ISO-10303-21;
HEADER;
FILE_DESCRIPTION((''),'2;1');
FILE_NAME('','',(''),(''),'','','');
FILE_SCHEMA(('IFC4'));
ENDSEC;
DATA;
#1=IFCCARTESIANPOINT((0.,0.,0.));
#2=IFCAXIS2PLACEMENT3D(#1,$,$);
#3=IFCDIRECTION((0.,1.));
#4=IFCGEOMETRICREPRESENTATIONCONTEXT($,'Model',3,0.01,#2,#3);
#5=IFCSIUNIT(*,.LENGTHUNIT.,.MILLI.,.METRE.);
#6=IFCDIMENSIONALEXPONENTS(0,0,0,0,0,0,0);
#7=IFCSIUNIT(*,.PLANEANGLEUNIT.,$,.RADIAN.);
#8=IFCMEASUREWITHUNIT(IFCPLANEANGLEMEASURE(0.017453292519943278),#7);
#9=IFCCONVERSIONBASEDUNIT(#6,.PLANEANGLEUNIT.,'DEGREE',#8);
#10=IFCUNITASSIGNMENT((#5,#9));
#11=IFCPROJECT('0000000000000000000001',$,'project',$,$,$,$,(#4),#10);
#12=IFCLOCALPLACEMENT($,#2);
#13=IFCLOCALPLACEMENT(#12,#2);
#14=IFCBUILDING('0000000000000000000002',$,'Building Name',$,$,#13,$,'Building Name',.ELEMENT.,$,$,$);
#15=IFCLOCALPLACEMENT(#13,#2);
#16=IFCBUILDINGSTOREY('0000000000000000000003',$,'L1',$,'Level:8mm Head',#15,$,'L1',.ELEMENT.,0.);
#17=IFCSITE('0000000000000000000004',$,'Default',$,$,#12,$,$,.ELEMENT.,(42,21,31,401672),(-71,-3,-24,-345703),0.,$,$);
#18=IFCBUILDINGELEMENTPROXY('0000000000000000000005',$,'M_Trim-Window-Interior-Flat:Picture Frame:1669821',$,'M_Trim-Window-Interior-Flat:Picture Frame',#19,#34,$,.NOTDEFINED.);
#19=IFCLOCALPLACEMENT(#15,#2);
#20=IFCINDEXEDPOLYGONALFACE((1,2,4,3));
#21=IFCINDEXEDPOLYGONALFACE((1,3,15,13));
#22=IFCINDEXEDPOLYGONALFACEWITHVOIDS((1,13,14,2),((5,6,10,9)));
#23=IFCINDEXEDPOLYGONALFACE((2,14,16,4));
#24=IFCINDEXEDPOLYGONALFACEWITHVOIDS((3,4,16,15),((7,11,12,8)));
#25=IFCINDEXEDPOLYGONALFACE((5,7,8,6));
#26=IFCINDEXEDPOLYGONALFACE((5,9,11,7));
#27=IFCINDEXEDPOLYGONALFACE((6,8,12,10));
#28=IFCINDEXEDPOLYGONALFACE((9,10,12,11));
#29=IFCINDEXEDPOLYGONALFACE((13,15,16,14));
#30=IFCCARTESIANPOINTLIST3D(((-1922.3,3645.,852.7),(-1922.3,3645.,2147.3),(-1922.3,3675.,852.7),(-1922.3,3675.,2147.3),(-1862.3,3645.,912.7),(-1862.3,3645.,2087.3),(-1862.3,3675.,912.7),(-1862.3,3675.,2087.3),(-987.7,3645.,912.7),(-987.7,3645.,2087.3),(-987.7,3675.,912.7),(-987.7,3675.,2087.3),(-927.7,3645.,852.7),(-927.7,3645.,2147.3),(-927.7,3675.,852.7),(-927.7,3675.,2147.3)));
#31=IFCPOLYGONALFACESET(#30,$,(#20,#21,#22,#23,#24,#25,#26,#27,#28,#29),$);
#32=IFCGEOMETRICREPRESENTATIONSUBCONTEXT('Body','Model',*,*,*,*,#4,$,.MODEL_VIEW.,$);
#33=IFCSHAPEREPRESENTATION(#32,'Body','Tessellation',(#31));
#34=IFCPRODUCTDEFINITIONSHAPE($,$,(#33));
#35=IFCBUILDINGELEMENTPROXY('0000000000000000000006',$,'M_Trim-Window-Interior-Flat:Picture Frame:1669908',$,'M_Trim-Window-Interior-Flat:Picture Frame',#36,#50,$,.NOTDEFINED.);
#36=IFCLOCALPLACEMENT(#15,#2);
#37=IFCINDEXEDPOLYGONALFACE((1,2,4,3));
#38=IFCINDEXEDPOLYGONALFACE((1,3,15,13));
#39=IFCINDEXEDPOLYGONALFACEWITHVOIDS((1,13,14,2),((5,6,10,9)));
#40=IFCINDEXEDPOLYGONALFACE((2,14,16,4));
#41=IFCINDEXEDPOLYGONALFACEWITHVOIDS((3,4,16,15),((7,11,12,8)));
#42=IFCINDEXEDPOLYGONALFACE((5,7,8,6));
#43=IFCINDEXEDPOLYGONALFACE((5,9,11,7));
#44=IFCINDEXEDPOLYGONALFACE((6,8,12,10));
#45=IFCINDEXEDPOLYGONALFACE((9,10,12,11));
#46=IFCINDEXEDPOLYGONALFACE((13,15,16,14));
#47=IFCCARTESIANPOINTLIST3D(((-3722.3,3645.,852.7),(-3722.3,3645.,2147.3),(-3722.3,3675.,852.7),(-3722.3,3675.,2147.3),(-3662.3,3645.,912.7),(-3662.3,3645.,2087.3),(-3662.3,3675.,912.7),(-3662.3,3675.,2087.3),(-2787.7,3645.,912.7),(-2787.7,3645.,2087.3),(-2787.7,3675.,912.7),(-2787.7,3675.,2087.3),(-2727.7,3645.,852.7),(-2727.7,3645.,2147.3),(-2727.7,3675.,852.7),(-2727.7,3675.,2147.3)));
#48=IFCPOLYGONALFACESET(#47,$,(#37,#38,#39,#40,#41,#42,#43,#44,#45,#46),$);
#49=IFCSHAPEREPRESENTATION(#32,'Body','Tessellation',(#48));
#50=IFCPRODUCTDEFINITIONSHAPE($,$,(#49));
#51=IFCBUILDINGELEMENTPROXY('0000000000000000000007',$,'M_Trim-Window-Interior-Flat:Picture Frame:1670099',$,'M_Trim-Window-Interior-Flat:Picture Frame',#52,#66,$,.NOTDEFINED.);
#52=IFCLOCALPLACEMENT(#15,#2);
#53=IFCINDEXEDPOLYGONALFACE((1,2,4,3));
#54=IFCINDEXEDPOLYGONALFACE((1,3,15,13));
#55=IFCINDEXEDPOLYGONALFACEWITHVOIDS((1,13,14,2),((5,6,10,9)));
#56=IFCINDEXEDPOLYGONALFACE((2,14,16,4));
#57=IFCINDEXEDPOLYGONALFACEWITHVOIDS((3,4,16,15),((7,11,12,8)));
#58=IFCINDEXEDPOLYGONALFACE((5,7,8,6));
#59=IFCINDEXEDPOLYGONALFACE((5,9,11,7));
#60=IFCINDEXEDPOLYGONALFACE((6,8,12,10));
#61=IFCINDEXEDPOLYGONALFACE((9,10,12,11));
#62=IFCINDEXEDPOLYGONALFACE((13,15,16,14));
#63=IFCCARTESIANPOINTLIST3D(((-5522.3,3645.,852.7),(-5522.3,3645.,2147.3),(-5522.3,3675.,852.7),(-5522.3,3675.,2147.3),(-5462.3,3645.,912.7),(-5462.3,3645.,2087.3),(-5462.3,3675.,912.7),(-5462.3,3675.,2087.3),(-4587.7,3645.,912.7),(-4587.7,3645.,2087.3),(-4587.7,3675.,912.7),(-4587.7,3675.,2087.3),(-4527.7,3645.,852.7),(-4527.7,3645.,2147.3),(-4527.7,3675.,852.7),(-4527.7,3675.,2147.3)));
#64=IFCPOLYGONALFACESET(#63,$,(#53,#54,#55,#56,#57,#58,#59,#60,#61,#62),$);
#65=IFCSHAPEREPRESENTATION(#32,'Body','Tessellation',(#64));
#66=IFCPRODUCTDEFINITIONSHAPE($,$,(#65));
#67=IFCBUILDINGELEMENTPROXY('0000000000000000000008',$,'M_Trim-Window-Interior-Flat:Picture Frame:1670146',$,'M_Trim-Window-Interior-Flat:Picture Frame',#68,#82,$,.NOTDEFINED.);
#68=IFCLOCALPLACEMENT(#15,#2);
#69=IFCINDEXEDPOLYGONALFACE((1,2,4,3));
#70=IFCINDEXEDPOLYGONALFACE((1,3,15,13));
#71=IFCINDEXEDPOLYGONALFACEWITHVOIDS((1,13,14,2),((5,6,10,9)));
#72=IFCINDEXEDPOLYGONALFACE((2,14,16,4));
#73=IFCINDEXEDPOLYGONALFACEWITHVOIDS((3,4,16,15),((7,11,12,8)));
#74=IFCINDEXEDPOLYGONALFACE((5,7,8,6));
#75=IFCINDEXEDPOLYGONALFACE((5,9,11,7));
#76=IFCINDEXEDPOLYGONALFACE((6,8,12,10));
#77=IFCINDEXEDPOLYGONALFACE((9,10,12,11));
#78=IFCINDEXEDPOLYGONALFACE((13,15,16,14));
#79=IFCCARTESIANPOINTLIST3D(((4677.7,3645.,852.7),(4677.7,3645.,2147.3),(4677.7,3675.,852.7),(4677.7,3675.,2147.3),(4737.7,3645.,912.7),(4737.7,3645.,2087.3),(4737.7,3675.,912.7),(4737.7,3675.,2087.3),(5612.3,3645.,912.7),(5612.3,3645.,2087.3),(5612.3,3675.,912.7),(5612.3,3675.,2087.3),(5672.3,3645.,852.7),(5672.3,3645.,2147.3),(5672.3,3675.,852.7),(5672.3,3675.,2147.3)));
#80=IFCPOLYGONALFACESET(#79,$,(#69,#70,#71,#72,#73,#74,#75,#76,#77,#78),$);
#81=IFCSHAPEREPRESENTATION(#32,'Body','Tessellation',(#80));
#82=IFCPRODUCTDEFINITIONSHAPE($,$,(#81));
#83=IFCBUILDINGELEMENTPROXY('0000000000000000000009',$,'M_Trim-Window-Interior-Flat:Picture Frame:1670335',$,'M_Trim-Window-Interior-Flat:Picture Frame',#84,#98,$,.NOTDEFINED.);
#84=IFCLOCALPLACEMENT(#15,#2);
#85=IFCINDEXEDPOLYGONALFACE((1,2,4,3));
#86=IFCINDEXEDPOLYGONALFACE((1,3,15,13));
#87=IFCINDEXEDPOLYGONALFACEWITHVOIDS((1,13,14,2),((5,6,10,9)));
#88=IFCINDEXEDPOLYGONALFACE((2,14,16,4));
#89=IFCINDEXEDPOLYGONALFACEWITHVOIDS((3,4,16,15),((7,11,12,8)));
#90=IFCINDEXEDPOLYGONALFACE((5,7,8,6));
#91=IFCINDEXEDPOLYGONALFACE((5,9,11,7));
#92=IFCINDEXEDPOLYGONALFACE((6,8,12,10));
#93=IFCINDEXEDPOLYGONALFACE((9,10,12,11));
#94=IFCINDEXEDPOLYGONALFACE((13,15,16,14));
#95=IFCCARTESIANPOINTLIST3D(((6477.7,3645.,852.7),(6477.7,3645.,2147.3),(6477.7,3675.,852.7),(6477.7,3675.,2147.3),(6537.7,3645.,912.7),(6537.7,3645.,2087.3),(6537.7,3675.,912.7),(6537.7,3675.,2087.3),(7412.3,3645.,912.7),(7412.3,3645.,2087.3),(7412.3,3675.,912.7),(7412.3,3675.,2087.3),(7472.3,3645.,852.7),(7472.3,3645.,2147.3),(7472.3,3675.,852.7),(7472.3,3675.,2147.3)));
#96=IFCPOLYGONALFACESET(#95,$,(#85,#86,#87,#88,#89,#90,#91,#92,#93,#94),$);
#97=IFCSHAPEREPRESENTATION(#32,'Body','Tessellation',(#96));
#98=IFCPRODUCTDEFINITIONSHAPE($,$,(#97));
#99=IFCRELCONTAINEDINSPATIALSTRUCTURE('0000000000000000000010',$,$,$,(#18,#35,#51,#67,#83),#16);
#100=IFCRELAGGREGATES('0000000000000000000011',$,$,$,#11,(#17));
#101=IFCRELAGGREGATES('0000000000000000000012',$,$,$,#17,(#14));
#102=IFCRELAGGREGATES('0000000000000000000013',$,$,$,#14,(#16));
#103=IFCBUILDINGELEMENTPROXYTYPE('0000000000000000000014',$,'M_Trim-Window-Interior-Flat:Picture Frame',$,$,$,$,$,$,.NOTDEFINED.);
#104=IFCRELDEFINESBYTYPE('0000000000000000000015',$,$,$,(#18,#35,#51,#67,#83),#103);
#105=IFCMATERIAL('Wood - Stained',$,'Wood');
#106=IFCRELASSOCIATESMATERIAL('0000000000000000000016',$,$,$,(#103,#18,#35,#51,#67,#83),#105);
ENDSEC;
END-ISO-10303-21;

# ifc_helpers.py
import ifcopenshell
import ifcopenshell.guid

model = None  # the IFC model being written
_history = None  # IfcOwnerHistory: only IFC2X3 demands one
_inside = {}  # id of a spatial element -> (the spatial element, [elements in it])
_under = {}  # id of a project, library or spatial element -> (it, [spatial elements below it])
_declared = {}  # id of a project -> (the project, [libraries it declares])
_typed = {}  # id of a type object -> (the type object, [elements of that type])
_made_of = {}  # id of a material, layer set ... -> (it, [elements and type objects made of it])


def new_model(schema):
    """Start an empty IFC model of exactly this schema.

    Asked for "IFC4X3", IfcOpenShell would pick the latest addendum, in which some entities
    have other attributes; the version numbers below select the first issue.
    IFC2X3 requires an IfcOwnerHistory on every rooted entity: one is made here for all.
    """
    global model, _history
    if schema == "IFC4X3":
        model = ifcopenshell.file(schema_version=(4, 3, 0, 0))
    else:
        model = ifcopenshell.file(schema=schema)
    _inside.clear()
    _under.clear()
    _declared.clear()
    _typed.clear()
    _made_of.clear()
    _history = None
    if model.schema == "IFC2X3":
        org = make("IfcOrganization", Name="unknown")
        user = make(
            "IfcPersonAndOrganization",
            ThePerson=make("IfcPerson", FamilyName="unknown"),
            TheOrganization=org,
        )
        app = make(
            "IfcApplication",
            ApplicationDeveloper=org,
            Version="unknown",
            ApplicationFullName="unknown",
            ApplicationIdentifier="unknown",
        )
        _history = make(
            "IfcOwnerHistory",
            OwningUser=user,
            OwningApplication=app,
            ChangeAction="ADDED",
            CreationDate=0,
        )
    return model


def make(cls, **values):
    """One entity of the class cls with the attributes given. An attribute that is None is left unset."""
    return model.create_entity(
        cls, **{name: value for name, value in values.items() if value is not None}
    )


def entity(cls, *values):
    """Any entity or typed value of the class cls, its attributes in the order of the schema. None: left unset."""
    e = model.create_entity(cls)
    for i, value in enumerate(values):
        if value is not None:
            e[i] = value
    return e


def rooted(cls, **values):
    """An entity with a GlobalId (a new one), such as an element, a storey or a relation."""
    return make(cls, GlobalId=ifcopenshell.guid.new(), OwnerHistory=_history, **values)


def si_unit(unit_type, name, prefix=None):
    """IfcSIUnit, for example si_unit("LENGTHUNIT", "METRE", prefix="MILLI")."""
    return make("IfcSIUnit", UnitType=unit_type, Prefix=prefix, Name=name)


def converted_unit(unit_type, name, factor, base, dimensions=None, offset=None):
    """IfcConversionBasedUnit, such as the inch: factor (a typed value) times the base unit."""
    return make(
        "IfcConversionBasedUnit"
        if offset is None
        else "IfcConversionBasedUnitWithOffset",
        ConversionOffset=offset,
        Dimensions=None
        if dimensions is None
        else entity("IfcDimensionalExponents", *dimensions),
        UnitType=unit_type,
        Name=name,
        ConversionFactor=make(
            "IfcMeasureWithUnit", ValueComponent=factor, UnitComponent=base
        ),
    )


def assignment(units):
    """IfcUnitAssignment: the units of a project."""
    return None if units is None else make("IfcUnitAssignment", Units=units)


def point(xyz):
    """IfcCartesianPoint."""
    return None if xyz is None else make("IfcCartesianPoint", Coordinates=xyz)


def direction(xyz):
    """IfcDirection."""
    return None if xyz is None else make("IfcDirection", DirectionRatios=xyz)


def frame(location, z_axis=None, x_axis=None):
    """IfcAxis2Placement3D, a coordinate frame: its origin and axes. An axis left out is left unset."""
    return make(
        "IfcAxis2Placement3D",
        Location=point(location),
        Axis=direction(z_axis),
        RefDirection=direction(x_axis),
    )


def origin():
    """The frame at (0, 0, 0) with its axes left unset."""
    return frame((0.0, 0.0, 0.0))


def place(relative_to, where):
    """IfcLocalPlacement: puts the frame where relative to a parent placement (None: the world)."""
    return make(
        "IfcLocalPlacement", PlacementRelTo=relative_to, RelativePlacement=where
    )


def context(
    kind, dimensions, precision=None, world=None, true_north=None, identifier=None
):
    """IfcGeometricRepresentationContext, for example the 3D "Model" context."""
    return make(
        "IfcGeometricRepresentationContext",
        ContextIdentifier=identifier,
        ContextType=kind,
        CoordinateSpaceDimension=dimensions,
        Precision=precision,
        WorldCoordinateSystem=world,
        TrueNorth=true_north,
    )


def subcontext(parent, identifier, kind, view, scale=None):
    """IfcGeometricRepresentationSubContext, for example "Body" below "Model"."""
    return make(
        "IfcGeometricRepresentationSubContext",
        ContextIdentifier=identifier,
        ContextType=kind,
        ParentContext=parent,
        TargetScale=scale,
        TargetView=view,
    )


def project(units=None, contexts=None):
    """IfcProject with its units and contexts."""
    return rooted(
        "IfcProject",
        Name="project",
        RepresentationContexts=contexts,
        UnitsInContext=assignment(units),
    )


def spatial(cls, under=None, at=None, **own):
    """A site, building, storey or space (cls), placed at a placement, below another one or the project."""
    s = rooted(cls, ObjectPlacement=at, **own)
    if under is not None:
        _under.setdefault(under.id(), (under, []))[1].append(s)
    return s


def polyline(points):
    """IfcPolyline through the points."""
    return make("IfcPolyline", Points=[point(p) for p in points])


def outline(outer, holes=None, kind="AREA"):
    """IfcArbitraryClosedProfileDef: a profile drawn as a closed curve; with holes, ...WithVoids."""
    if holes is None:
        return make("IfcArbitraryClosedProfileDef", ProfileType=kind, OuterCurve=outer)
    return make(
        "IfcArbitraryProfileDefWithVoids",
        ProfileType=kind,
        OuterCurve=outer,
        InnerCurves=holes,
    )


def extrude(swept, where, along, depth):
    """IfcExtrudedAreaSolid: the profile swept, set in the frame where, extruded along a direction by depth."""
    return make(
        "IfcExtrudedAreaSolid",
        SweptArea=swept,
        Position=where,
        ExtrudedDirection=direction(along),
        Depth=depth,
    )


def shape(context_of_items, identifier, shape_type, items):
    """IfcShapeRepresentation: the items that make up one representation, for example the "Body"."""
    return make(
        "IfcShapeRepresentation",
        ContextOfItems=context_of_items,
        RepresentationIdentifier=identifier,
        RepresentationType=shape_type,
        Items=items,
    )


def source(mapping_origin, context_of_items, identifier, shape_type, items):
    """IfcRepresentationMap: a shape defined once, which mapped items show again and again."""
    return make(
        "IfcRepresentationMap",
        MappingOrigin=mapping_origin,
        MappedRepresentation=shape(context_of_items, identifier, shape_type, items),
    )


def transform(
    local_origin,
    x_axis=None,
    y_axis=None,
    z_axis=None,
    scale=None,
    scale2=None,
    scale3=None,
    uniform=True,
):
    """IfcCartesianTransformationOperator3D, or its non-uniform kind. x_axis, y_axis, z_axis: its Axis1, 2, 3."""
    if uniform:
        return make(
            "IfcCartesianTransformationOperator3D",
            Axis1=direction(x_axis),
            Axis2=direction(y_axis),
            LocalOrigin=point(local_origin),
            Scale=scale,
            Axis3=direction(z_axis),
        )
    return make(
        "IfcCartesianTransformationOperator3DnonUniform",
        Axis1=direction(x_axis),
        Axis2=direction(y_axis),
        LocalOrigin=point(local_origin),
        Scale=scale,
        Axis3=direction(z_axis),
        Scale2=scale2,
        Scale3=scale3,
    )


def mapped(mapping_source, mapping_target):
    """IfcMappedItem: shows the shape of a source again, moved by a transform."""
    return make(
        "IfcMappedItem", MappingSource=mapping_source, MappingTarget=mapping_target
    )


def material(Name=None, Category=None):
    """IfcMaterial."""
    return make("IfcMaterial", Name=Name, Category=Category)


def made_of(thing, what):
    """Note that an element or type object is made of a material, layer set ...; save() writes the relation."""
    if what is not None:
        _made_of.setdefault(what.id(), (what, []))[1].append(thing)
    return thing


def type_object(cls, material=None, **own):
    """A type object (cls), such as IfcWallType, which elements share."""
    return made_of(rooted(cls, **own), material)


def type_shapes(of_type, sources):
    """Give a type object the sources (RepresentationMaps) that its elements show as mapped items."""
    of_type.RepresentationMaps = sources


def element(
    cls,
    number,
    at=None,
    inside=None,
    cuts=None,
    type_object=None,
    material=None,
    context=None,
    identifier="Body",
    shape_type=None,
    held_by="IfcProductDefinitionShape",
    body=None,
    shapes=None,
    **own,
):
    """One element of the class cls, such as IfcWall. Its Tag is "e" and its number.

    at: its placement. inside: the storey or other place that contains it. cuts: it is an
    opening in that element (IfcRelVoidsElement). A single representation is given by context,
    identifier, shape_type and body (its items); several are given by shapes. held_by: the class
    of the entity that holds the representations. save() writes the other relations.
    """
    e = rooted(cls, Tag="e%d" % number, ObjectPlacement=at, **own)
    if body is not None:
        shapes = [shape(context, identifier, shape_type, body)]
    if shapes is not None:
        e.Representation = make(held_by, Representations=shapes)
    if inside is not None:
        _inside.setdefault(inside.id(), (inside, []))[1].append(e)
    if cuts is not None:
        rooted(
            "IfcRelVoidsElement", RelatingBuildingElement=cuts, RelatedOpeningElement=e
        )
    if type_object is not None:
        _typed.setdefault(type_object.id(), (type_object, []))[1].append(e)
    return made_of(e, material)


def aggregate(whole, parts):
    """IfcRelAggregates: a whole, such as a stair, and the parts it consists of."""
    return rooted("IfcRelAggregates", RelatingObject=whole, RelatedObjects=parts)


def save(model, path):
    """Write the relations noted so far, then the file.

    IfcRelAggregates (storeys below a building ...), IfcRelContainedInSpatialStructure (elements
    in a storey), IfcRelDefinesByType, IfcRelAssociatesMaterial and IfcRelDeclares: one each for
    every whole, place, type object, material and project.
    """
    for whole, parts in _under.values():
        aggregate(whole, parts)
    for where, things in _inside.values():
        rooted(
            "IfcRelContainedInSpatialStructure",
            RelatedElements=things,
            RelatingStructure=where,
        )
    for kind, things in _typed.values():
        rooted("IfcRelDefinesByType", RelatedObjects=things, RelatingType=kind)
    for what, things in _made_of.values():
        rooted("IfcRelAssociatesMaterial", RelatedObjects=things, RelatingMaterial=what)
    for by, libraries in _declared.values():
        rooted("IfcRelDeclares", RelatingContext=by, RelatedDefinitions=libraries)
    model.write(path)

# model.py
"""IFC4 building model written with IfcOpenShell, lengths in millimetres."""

from ifc_helpers import new_model, entity, si_unit, converted_unit, direction, frame, origin, place, context, subcontext, project, spatial, polyline, outline, extrude, source, transform, mapped, material, type_object, type_shapes, element, save


model = new_model("IFC4")

# Units and contexts
model_context = context("Model", 3, precision=0.01, world=origin(), true_north=direction((0.0, 1.0)))
body_context = subcontext(model_context, "Body", "Model", "MODEL_VIEW")
ifc_project = project(units=[si_unit("LENGTHUNIT", "METRE", prefix="MILLI"), converted_unit("PLANEANGLEUNIT", "DEGREE", entity("IfcPlaneAngleMeasure", 0.017453292519943278), si_unit("PLANEANGLEUNIT", "RADIAN"), dimensions=[0, 0, 0, 0, 0, 0, 0])], contexts=[model_context])

# Site, building, storey
site_placement = place(None, origin())
site = spatial("IfcSite", under=ifc_project, at=site_placement, Name="Default", CompositionType="ELEMENT", RefLatitude=(42, 21, 31, 401672), RefLongitude=(-71, -3, -24, -345703), RefElevation=0.0)
building_placement = place(site_placement, origin())
building = spatial("IfcBuilding", under=site, at=building_placement, Name="Building Name", LongName="Building Name", CompositionType="ELEMENT")
storey_placement = place(building_placement, origin())
storey = spatial("IfcBuildingStorey", under=building, at=storey_placement, Name="L1", ObjectType="Level:8mm Head", LongName="L1", CompositionType="ELEMENT", Elevation=0.0)

# Shared definitions
ifc_material_1 = material(Name="Wood - Stained", Category="Wood")

# Building element proxies
building_element_proxy_type_1 = type_object("IfcBuildingElementProxyType", Name="M_Trim-Window-Interior-Flat:Picture Frame", PredefinedType="NOTDEFINED", material=ifc_material_1)
shared_shape_1 = source(origin(), body_context, "Body", "SweptSolid", [
    extrude(outline(polyline([(-497.3, -647.3), (497.3, -647.3), (497.3, 647.3), (-497.3, 647.3), (-497.3, -647.3)]), holes=[polyline([(-437.3, -587.3), (-437.3, 587.3), (437.3, 587.3), (437.3, -587.3), (-437.3, -587.3)])]), frame((0.0, -600.0, 0.0), z_axis=(0.0, 0.0, 1.0), x_axis=(-1.0, 0.0, 0.0)), (0.0, 0.0, 1.0), 30.0),
])
type_shapes(building_element_proxy_type_1, [shared_shape_1])
for number, where, z_axis, x_axis, name in (
    (1, (-1425.0, 3675.0, 2100.0), (0.0, -1.0, 0.0), (1.0, 0.0, 0.0), "M_Trim-Window-Interior-Flat:Picture Frame:1669821"),
    (2, (-3225.0, 3675.0, 2100.0), (0.0, -1.0, 0.0), (1.0, 0.0, 0.0), "M_Trim-Window-Interior-Flat:Picture Frame:1669908"),
    (3, (-5025.0, 3675.0, 2100.0), (0.0, -1.0, 0.0), (1.0, 0.0, 0.0), "M_Trim-Window-Interior-Flat:Picture Frame:1670099"),
    (4, (5175.0, 3675.0, 2100.0), (0.0, -1.0, 0.0), (1.0, 0.0, 0.0), "M_Trim-Window-Interior-Flat:Picture Frame:1670146"),
    (5, (6975.0, 3675.0, 2100.0), (0.0, -1.0, 0.0), (1.0, 0.0, 0.0), "M_Trim-Window-Interior-Flat:Picture Frame:1670335"),
):
    element("IfcBuildingElementProxy", number, at=place(storey_placement, frame(where, z_axis=z_axis, x_axis=x_axis)), inside=storey, type_object=building_element_proxy_type_1, material=ifc_material_1, Name=name, ObjectType="M_Trim-Window-Interior-Flat:Picture Frame", PredefinedType="NOTDEFINED", context=body_context, shape_type="MappedRepresentation", body=[
        mapped(shared_shape_1, transform((0.0, 0.0, 0.0), scale=1.0)),
    ])

save(model, "model.ifc")
